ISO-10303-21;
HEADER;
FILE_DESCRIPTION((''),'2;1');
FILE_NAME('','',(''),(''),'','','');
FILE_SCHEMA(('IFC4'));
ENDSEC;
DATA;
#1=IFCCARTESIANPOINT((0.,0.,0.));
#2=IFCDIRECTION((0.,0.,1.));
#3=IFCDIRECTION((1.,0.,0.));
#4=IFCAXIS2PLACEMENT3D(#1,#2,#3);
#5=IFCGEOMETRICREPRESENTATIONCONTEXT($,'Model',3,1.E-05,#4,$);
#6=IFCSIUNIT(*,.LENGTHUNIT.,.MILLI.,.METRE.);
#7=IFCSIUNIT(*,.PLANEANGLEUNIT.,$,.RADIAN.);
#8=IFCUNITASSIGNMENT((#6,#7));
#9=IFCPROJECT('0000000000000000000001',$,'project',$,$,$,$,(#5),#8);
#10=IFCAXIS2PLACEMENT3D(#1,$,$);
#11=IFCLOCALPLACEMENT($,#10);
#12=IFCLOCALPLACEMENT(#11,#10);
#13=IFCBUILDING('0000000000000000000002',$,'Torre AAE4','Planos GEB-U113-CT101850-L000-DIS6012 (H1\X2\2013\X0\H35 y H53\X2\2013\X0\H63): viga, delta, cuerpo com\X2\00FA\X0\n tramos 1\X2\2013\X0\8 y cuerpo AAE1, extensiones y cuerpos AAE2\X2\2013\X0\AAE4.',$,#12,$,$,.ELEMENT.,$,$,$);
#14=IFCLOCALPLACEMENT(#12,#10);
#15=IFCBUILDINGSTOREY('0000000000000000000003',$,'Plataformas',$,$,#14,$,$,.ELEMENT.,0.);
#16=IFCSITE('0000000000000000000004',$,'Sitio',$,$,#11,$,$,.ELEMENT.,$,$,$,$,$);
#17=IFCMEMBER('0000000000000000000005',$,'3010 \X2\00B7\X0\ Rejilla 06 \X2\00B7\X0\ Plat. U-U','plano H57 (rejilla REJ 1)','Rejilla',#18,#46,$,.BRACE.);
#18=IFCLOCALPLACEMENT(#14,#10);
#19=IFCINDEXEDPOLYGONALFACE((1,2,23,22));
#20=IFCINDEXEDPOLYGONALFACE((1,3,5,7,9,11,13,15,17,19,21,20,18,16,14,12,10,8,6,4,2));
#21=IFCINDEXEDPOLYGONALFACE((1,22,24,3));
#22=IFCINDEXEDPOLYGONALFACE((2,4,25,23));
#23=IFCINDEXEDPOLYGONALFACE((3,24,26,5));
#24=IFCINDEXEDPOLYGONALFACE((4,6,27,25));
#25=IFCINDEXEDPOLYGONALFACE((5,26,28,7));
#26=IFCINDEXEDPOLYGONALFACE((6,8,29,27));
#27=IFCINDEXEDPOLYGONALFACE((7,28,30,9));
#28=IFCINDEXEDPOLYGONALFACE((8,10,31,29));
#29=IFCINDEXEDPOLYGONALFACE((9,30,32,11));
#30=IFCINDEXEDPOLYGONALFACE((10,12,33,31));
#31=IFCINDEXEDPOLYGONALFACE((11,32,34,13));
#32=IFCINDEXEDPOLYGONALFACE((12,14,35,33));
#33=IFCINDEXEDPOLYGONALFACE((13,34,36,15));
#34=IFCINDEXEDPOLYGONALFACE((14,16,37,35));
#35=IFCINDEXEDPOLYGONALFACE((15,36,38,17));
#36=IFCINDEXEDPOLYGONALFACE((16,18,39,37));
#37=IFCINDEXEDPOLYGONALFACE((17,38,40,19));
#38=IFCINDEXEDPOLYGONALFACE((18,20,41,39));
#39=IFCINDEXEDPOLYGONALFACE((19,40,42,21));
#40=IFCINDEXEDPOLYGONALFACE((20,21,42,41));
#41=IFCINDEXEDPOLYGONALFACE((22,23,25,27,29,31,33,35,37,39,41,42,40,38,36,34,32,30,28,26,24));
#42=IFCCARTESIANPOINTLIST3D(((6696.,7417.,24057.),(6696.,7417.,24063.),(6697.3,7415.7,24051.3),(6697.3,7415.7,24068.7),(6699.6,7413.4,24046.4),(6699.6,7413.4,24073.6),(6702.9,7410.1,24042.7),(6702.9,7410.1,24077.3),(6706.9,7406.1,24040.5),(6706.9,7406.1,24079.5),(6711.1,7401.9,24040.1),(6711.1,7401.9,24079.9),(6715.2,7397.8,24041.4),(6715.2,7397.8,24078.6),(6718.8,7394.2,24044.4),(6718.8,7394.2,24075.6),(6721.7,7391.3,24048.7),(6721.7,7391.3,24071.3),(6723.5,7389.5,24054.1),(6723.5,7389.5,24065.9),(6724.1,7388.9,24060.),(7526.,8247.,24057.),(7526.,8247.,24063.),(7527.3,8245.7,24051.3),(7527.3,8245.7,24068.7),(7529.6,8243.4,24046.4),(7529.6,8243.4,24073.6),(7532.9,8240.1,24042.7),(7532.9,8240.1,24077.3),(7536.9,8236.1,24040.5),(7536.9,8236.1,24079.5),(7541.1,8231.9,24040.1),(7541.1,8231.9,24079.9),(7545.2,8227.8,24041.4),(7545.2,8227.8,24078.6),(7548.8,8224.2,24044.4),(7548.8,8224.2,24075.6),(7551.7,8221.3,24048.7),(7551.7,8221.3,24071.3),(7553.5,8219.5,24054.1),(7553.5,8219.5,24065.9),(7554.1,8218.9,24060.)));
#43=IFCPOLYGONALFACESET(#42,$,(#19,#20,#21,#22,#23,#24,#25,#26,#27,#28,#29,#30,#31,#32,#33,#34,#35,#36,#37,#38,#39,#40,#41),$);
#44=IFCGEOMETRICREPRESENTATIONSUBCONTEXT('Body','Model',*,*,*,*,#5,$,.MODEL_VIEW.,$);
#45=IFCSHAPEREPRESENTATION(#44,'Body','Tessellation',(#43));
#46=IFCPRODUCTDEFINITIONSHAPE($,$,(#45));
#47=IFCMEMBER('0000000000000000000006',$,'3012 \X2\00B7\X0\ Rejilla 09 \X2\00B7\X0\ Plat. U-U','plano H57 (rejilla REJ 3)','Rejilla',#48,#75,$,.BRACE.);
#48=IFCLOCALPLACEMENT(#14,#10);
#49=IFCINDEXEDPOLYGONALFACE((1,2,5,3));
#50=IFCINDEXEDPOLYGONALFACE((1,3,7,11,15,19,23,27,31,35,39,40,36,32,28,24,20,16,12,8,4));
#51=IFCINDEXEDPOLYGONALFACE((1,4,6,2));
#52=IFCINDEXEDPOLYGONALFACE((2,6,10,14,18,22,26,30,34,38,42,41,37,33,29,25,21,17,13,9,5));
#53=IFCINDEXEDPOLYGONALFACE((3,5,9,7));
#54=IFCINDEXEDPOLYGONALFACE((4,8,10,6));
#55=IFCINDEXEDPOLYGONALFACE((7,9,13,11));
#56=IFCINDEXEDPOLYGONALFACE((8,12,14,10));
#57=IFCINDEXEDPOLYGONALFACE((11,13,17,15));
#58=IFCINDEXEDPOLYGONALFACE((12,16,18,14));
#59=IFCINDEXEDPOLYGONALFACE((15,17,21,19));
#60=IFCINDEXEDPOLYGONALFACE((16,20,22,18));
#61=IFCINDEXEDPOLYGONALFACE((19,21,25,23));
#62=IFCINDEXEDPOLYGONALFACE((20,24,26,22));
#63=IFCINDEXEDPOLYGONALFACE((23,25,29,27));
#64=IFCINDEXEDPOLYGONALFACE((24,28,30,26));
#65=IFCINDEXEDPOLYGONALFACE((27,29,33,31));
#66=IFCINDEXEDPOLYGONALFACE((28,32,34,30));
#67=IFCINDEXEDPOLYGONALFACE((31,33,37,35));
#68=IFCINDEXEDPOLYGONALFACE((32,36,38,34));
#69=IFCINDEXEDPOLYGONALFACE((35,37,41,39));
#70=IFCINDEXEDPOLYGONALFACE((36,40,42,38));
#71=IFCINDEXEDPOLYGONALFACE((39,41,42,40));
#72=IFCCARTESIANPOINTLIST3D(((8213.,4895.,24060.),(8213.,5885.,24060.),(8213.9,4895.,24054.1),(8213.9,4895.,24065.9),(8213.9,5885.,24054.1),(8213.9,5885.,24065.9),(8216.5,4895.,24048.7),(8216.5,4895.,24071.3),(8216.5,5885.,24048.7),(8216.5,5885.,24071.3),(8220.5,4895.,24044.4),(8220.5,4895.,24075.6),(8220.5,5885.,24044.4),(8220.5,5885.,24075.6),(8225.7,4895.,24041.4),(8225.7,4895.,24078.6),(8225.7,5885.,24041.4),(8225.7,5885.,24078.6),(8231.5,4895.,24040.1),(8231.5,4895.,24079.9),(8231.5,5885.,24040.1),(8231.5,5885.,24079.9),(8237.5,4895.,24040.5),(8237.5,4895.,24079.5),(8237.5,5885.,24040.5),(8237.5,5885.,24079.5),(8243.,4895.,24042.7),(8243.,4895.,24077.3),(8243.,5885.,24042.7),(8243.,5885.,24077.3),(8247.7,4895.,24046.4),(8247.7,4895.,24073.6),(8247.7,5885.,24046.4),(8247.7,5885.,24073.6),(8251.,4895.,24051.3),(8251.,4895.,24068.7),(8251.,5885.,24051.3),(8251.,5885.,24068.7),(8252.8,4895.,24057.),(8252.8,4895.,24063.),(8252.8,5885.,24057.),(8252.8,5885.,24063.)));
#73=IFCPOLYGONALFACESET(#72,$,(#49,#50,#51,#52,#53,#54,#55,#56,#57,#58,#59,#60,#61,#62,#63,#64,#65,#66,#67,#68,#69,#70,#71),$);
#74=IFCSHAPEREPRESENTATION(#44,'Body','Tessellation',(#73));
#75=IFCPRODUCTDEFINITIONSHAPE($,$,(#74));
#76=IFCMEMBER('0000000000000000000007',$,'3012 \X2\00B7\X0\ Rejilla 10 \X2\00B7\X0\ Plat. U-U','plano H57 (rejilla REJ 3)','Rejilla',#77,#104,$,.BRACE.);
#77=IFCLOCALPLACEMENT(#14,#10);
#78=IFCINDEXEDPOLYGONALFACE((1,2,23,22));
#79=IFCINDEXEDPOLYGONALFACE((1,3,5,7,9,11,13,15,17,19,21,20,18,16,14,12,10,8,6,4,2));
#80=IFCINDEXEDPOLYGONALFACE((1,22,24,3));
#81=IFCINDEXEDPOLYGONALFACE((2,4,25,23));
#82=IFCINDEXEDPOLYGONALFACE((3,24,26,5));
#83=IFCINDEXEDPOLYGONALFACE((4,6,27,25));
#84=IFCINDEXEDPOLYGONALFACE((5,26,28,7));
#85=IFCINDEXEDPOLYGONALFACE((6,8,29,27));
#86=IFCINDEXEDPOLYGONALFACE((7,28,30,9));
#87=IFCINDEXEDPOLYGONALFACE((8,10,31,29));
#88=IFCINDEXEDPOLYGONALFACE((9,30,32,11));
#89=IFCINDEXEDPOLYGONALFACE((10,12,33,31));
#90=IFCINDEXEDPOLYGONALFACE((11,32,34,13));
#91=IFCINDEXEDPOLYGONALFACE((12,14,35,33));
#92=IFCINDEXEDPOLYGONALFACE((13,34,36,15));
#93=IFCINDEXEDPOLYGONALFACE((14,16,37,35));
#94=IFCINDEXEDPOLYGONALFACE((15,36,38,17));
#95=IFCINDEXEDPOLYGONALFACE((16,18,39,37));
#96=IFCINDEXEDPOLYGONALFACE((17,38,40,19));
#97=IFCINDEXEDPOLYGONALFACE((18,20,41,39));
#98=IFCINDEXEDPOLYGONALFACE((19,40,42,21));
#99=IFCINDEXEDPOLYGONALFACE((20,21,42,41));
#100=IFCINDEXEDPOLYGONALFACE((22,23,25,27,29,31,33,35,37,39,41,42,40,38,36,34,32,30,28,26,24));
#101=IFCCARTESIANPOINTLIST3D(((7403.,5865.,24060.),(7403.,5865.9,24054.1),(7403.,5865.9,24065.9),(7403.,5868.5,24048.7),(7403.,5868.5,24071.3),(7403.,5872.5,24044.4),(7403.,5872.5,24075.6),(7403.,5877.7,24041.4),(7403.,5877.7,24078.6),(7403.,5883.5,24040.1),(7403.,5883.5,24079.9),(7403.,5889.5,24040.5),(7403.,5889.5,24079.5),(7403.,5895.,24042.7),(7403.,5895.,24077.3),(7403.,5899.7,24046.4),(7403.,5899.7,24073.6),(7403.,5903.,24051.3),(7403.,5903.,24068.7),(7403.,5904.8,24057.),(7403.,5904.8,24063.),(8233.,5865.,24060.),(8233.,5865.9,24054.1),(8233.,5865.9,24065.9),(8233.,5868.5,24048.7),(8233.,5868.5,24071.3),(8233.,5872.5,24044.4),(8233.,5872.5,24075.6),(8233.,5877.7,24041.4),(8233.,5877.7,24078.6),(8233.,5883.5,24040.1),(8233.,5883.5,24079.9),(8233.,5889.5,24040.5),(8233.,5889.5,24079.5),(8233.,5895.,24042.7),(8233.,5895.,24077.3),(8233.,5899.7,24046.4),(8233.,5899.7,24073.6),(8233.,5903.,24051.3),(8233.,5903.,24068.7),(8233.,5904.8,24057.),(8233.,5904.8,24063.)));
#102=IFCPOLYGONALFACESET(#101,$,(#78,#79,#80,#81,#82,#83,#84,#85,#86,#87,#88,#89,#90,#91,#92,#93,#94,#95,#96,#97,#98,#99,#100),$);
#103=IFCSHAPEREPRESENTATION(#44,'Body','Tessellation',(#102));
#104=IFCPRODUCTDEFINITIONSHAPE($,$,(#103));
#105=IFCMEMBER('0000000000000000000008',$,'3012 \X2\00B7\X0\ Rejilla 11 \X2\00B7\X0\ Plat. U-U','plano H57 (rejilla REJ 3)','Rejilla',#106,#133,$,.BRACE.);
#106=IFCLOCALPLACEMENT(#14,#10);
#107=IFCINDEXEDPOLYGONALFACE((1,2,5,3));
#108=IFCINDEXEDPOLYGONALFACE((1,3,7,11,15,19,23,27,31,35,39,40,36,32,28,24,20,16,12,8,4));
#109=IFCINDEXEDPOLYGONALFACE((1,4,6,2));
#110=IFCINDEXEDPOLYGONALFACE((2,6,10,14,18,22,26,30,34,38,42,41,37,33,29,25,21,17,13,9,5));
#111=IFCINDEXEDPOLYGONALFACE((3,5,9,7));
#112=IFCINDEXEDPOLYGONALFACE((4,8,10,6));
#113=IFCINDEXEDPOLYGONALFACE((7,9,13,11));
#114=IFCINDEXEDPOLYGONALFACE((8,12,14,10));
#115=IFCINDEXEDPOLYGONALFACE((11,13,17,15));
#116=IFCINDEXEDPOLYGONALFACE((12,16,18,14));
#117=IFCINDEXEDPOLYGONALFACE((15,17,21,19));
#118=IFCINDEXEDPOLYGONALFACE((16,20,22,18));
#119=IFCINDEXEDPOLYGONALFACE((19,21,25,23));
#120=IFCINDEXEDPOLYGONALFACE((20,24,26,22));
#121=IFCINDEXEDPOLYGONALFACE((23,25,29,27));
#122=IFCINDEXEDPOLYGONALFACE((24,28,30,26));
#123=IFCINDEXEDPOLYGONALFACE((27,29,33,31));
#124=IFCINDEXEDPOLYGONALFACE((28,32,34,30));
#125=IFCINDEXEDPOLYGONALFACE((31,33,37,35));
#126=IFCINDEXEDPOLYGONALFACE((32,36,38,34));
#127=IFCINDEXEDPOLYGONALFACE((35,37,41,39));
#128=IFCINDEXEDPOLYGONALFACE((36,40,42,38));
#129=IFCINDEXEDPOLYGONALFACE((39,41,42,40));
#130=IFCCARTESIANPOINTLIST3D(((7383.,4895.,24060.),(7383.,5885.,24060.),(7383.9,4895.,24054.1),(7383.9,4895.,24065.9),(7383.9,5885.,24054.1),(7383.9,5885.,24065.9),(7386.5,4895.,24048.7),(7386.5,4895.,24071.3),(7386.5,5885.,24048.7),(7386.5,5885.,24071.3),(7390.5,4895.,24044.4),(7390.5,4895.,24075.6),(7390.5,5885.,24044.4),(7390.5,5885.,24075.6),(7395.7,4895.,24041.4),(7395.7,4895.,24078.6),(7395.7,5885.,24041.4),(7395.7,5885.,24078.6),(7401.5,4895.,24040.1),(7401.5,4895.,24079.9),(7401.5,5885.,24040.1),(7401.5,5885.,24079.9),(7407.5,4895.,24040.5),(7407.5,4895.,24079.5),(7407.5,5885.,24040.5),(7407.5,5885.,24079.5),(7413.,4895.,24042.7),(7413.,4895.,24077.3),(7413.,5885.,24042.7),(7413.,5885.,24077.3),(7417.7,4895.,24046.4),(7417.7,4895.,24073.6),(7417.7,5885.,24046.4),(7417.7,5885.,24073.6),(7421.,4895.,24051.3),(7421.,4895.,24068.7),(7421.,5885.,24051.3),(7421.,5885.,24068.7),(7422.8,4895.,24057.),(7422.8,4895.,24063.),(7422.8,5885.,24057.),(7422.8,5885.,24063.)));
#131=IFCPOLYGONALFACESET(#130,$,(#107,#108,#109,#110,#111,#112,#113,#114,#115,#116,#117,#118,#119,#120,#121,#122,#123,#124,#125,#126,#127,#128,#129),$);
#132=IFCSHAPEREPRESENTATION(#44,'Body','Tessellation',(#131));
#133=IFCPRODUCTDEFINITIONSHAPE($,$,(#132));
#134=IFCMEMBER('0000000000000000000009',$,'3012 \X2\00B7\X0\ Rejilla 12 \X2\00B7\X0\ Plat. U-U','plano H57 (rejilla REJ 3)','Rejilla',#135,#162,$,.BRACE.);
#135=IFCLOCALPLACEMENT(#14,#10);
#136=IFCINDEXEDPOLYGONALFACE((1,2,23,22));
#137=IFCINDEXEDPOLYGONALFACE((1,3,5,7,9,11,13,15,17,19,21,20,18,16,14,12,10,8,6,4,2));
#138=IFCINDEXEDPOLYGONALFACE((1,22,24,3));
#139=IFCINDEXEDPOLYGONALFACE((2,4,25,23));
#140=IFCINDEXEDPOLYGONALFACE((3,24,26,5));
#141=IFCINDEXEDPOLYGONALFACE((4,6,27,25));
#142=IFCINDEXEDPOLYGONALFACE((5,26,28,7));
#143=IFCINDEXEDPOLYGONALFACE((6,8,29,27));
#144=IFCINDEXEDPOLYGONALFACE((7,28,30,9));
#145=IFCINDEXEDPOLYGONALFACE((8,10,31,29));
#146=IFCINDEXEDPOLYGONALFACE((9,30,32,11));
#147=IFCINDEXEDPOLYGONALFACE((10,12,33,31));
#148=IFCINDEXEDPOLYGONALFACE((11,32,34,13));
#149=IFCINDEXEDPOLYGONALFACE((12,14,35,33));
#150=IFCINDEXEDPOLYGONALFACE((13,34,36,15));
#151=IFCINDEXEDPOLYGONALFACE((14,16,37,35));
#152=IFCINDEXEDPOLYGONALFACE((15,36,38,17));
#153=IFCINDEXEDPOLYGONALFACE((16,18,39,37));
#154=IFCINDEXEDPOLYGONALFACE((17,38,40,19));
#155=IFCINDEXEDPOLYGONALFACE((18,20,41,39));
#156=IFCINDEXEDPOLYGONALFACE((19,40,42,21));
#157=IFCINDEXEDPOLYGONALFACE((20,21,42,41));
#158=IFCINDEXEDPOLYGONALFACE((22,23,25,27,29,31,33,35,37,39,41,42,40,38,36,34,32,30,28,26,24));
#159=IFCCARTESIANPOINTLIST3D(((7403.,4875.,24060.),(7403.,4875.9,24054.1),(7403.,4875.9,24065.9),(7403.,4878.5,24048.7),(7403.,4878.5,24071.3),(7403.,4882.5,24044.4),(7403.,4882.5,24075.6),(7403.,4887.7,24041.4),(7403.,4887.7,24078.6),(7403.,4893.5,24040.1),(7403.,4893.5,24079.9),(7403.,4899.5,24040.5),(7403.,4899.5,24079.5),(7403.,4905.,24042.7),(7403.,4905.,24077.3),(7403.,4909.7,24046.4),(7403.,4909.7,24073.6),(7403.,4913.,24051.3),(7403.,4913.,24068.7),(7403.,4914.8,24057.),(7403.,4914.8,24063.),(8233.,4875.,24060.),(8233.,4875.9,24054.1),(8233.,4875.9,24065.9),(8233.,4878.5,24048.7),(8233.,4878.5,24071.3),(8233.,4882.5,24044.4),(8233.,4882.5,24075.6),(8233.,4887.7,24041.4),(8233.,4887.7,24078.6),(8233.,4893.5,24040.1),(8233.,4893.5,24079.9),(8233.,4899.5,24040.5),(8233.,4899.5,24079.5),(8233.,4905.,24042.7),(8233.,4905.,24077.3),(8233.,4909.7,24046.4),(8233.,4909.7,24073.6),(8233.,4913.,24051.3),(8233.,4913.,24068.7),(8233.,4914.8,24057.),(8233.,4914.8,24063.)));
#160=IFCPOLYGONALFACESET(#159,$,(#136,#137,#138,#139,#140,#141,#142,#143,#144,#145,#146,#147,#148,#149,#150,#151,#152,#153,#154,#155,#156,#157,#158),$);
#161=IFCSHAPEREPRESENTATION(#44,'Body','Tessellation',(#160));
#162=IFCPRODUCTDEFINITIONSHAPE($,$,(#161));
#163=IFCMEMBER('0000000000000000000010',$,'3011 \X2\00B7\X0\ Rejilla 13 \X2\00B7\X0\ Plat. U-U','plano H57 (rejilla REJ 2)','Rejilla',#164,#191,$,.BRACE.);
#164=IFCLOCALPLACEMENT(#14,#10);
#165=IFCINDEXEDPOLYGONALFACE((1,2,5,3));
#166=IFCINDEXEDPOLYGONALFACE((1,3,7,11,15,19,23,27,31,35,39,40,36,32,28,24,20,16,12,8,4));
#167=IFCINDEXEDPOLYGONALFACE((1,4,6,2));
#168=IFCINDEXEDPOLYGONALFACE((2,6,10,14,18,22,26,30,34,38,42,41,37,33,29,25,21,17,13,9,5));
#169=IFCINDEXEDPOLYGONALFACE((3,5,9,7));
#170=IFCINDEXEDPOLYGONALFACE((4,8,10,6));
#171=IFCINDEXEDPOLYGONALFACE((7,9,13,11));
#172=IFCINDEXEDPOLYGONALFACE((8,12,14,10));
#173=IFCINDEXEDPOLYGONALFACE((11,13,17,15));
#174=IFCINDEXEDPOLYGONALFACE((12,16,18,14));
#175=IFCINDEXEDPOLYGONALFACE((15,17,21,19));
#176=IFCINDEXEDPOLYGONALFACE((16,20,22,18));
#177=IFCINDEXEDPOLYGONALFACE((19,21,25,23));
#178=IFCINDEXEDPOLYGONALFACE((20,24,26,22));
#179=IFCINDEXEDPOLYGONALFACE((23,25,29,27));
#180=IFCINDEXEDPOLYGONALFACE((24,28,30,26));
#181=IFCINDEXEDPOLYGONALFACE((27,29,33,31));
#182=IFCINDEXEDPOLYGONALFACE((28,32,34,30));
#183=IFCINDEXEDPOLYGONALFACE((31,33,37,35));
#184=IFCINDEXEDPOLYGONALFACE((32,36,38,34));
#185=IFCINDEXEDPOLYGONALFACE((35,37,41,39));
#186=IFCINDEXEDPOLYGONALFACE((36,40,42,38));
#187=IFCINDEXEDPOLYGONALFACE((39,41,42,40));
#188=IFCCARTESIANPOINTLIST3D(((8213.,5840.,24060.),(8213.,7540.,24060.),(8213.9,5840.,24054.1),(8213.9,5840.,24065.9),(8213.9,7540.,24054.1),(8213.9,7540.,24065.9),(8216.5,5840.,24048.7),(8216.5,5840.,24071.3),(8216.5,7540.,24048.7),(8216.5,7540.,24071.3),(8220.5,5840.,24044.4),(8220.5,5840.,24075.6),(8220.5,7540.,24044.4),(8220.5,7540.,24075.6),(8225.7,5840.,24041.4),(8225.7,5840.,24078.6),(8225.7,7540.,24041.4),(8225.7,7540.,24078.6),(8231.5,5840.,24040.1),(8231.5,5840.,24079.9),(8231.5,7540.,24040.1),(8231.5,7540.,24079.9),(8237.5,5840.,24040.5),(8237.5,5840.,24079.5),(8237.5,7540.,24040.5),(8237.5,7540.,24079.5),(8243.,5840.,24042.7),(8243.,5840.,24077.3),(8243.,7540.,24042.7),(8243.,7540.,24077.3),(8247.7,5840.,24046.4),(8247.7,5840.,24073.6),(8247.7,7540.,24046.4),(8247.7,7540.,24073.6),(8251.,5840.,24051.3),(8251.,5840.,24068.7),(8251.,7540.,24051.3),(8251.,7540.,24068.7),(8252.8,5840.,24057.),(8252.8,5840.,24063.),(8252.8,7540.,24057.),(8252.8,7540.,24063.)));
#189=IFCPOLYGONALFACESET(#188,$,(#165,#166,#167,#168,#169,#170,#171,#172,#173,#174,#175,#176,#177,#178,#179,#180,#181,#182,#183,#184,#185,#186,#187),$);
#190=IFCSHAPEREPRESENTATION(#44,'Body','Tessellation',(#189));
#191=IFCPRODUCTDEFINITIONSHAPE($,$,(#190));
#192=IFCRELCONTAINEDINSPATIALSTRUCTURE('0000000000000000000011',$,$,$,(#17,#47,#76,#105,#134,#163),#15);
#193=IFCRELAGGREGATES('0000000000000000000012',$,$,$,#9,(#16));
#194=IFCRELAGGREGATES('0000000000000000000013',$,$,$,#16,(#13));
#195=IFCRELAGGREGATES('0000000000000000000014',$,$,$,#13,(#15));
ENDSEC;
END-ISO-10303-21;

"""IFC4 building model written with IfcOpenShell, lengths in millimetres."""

from ifc_helpers import new_model, si_unit, frame, origin, origin_with_axes, place, context, subcontext, project, spatial, circle, extrude, element, save


model = new_model("IFC4")

# Units and contexts
model_context = context("Model", 3, precision=1e-05, world=origin_with_axes())
body_context = subcontext(model_context, "Body", "Model", "MODEL_VIEW")
ifc_project = project(units=[si_unit("LENGTHUNIT", "METRE", prefix="MILLI"), si_unit("PLANEANGLEUNIT", "RADIAN")], contexts=[model_context])

# Site, building, storey
site_placement = place(None, origin())
site = spatial("IfcSite", under=ifc_project, at=site_placement, Name="Sitio", CompositionType="ELEMENT")
building_placement = place(site_placement, origin())
building = spatial("IfcBuilding", under=site, at=building_placement, Name="Torre AAE4", Description="Planos GEB-U113-CT101850-L000-DIS6012 (H1–H35 y H53–H63): viga, delta, cuerpo común tramos 1–8 y cuerpo AAE1, extensiones y cuerpos AAE2–AAE4.", CompositionType="ELEMENT")
storey_placement = place(building_placement, origin())
storey = spatial("IfcBuildingStorey", under=building, at=storey_placement, Name="Plataformas", CompositionType="ELEMENT", Elevation=0.0)

# Members
member_1_placement = place(storey_placement, frame((7540.0, 8233.0, 24060.0), z_axis=(-0.707107, -0.707107, 0.0), x_axis=(0.707107, -0.707107, 0.0)))
element("IfcMember", 1, at=member_1_placement, inside=storey, Name="3010 · Rejilla 06 · Plat. U-U", Description="plano H57 (rejilla REJ 1)", ObjectType="Rejilla", PredefinedType="BRACE", context=body_context, shape_type="SweptSolid", body=[
    extrude(circle(Radius=20.0), None, (0.0, 0.0, 1.0), 1173.8),
])
member_2_placement = place(storey_placement, frame((8233.0, 4895.0, 24060.0), z_axis=(0.0, 1.0, 0.0), x_axis=(-1.0, 0.0, 0.0)))
element("IfcMember", 2, at=member_2_placement, inside=storey, Name="3012 · Rejilla 09 · Plat. U-U", Description="plano H57 (rejilla REJ 3)", ObjectType="Rejilla", PredefinedType="BRACE", context=body_context, shape_type="SweptSolid", body=[
    extrude(circle(Radius=20.0), None, (0.0, 0.0, 1.0), 990.0),
])
member_3_placement = place(storey_placement, frame((8233.0, 5885.0, 24060.0), z_axis=(-1.0, 0.0, 0.0), x_axis=(0.0, -1.0, 0.0)))
element("IfcMember", 3, at=member_3_placement, inside=storey, Name="3012 · Rejilla 10 · Plat. U-U", Description="plano H57 (rejilla REJ 3)", ObjectType="Rejilla", PredefinedType="BRACE", context=body_context, shape_type="SweptSolid", body=[
    extrude(circle(Radius=20.0), None, (0.0, 0.0, 1.0), 830.0),
])
member_4_placement = place(storey_placement, frame((7403.0, 5885.0, 24060.0), z_axis=(0.0, -1.0, 0.0), x_axis=(-1.0, 0.0, 0.0)))
element("IfcMember", 4, at=member_4_placement, inside=storey, Name="3012 · Rejilla 11 · Plat. U-U", Description="plano H57 (rejilla REJ 3)", ObjectType="Rejilla", PredefinedType="BRACE", context=body_context, shape_type="SweptSolid", body=[
    extrude(circle(Radius=20.0), None, (0.0, 0.0, 1.0), 990.0),
])
member_5_placement = place(storey_placement, frame((7403.0, 4895.0, 24060.0), z_axis=(1.0, 0.0, 0.0), x_axis=(0.0, -1.0, 0.0)))
element("IfcMember", 5, at=member_5_placement, inside=storey, Name="3012 · Rejilla 12 · Plat. U-U", Description="plano H57 (rejilla REJ 3)", ObjectType="Rejilla", PredefinedType="BRACE", context=body_context, shape_type="SweptSolid", body=[
    extrude(circle(Radius=20.0), None, (0.0, 0.0, 1.0), 830.0),
])
member_6_placement = place(storey_placement, frame((8233.0, 5840.0, 24060.0), z_axis=(0.0, 1.0, 0.0), x_axis=(-1.0, 0.0, 0.0)))
element("IfcMember", 6, at=member_6_placement, inside=storey, Name="3011 · Rejilla 13 · Plat. U-U", Description="plano H57 (rejilla REJ 2)", ObjectType="Rejilla", PredefinedType="BRACE", context=body_context, shape_type="SweptSolid", body=[
    extrude(circle(Radius=20.0), None, (0.0, 0.0, 1.0), 1700.0),
])

save(model, "model.ifc")
